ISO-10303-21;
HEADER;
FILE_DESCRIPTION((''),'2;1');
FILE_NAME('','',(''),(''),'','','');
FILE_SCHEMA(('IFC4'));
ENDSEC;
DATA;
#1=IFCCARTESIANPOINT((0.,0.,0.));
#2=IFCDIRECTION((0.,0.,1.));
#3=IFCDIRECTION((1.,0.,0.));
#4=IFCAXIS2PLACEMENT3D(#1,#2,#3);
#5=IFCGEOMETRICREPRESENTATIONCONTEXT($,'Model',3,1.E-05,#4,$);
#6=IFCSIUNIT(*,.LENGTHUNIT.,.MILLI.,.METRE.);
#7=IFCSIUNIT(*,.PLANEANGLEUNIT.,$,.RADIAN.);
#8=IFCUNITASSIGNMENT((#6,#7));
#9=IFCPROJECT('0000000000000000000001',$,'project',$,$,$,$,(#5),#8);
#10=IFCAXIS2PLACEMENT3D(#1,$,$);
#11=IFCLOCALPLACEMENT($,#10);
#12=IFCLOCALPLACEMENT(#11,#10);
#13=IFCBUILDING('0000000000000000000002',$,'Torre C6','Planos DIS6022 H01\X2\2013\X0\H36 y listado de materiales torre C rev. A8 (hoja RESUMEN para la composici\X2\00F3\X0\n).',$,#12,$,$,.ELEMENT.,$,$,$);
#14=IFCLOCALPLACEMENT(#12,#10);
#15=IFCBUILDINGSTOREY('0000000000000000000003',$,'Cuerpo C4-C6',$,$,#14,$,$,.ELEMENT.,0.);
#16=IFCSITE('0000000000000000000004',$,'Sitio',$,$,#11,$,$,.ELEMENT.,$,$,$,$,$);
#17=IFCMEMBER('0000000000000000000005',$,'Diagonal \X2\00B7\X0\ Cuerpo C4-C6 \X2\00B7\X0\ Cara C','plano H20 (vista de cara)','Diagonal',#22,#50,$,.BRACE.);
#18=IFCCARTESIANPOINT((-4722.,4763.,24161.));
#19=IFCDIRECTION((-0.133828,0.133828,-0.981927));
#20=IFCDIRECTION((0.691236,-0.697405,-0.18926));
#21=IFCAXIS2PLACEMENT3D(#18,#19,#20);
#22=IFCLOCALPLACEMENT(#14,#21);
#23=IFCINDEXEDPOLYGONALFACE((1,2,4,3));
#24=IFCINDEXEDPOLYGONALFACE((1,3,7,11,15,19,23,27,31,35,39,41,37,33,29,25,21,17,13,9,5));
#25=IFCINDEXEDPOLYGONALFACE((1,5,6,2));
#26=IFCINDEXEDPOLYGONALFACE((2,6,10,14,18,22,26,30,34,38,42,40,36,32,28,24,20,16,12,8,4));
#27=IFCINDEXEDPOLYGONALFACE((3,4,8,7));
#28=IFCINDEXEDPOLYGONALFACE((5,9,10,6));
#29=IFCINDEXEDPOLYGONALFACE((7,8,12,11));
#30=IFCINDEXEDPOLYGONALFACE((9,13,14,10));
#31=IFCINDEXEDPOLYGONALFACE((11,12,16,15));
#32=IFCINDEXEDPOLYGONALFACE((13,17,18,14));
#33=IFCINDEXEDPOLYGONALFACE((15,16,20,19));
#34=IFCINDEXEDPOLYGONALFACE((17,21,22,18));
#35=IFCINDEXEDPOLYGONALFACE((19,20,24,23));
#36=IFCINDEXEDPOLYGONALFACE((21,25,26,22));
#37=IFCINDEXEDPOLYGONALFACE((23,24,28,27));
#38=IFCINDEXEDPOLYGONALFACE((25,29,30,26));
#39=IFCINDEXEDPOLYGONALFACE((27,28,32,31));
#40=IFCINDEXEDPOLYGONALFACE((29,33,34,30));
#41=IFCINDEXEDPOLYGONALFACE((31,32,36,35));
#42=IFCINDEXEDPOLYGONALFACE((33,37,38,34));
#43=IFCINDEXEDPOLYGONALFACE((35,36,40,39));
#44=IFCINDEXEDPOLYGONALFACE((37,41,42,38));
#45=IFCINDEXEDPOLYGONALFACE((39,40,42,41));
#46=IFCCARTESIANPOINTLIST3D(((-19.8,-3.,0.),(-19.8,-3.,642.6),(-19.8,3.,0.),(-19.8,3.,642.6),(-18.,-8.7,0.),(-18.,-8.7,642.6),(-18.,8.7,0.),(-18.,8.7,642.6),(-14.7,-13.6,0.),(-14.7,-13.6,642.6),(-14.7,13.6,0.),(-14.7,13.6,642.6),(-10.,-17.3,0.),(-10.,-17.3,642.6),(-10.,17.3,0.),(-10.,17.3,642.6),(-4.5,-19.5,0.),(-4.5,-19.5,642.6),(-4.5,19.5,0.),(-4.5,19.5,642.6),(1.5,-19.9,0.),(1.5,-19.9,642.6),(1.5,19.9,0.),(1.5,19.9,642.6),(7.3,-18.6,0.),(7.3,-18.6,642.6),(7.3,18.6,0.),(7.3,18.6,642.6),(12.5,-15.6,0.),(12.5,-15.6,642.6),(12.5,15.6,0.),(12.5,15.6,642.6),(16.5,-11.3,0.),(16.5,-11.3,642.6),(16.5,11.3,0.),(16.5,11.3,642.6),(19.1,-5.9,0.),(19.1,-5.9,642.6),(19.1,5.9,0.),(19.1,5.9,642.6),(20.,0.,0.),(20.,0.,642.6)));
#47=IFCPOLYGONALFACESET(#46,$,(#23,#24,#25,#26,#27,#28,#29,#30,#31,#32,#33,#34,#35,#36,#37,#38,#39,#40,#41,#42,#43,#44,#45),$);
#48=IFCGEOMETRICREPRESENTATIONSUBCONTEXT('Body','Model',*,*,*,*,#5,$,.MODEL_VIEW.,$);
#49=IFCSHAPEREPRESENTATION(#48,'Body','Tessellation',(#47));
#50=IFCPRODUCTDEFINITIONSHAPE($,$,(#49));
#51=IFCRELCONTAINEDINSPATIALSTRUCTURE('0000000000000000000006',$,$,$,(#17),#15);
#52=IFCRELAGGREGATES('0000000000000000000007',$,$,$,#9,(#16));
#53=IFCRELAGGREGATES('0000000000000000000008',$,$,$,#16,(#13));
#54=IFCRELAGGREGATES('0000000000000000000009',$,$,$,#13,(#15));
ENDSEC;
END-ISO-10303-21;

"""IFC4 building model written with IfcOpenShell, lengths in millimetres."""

from ifc_helpers import new_model, si_unit, frame, origin, origin_with_axes, place, context, subcontext, project, spatial, circle, extrude, element, save


model = new_model("IFC4")

# Units and contexts
model_context = context("Model", 3, precision=1e-05, world=origin_with_axes())
body_context = subcontext(model_context, "Body", "Model", "MODEL_VIEW")
ifc_project = project(units=[si_unit("LENGTHUNIT", "METRE", prefix="MILLI"), si_unit("PLANEANGLEUNIT", "RADIAN")], contexts=[model_context])

# Site, building, storey
site_placement = place(None, origin())
site = spatial("IfcSite", under=ifc_project, at=site_placement, Name="Sitio", CompositionType="ELEMENT")
building_placement = place(site_placement, origin())
building = spatial("IfcBuilding", under=site, at=building_placement, Name="Torre C6", Description="Planos DIS6022 H01–H36 y listado de materiales torre C rev. A8 (hoja RESUMEN para la composición).", CompositionType="ELEMENT")
storey_placement = place(building_placement, origin())
storey = spatial("IfcBuildingStorey", under=building, at=storey_placement, Name="Cuerpo C4-C6", CompositionType="ELEMENT", Elevation=0.0)

# Member
member_1_placement = place(storey_placement, frame((-4722.0, 4763.0, 24161.0), z_axis=(-0.133828, 0.133828, -0.981927), x_axis=(0.691236, -0.697405, -0.18926)))
element("IfcMember", 1, at=member_1_placement, inside=storey, Name="Diagonal · Cuerpo C4-C6 · Cara C", Description="plano H20 (vista de cara)", ObjectType="Diagonal", PredefinedType="BRACE", context=body_context, shape_type="SweptSolid", body=[
    extrude(circle(Radius=20.0), None, (0.0, 0.0, 1.0), 642.6),
])

save(model, "model.ifc")
